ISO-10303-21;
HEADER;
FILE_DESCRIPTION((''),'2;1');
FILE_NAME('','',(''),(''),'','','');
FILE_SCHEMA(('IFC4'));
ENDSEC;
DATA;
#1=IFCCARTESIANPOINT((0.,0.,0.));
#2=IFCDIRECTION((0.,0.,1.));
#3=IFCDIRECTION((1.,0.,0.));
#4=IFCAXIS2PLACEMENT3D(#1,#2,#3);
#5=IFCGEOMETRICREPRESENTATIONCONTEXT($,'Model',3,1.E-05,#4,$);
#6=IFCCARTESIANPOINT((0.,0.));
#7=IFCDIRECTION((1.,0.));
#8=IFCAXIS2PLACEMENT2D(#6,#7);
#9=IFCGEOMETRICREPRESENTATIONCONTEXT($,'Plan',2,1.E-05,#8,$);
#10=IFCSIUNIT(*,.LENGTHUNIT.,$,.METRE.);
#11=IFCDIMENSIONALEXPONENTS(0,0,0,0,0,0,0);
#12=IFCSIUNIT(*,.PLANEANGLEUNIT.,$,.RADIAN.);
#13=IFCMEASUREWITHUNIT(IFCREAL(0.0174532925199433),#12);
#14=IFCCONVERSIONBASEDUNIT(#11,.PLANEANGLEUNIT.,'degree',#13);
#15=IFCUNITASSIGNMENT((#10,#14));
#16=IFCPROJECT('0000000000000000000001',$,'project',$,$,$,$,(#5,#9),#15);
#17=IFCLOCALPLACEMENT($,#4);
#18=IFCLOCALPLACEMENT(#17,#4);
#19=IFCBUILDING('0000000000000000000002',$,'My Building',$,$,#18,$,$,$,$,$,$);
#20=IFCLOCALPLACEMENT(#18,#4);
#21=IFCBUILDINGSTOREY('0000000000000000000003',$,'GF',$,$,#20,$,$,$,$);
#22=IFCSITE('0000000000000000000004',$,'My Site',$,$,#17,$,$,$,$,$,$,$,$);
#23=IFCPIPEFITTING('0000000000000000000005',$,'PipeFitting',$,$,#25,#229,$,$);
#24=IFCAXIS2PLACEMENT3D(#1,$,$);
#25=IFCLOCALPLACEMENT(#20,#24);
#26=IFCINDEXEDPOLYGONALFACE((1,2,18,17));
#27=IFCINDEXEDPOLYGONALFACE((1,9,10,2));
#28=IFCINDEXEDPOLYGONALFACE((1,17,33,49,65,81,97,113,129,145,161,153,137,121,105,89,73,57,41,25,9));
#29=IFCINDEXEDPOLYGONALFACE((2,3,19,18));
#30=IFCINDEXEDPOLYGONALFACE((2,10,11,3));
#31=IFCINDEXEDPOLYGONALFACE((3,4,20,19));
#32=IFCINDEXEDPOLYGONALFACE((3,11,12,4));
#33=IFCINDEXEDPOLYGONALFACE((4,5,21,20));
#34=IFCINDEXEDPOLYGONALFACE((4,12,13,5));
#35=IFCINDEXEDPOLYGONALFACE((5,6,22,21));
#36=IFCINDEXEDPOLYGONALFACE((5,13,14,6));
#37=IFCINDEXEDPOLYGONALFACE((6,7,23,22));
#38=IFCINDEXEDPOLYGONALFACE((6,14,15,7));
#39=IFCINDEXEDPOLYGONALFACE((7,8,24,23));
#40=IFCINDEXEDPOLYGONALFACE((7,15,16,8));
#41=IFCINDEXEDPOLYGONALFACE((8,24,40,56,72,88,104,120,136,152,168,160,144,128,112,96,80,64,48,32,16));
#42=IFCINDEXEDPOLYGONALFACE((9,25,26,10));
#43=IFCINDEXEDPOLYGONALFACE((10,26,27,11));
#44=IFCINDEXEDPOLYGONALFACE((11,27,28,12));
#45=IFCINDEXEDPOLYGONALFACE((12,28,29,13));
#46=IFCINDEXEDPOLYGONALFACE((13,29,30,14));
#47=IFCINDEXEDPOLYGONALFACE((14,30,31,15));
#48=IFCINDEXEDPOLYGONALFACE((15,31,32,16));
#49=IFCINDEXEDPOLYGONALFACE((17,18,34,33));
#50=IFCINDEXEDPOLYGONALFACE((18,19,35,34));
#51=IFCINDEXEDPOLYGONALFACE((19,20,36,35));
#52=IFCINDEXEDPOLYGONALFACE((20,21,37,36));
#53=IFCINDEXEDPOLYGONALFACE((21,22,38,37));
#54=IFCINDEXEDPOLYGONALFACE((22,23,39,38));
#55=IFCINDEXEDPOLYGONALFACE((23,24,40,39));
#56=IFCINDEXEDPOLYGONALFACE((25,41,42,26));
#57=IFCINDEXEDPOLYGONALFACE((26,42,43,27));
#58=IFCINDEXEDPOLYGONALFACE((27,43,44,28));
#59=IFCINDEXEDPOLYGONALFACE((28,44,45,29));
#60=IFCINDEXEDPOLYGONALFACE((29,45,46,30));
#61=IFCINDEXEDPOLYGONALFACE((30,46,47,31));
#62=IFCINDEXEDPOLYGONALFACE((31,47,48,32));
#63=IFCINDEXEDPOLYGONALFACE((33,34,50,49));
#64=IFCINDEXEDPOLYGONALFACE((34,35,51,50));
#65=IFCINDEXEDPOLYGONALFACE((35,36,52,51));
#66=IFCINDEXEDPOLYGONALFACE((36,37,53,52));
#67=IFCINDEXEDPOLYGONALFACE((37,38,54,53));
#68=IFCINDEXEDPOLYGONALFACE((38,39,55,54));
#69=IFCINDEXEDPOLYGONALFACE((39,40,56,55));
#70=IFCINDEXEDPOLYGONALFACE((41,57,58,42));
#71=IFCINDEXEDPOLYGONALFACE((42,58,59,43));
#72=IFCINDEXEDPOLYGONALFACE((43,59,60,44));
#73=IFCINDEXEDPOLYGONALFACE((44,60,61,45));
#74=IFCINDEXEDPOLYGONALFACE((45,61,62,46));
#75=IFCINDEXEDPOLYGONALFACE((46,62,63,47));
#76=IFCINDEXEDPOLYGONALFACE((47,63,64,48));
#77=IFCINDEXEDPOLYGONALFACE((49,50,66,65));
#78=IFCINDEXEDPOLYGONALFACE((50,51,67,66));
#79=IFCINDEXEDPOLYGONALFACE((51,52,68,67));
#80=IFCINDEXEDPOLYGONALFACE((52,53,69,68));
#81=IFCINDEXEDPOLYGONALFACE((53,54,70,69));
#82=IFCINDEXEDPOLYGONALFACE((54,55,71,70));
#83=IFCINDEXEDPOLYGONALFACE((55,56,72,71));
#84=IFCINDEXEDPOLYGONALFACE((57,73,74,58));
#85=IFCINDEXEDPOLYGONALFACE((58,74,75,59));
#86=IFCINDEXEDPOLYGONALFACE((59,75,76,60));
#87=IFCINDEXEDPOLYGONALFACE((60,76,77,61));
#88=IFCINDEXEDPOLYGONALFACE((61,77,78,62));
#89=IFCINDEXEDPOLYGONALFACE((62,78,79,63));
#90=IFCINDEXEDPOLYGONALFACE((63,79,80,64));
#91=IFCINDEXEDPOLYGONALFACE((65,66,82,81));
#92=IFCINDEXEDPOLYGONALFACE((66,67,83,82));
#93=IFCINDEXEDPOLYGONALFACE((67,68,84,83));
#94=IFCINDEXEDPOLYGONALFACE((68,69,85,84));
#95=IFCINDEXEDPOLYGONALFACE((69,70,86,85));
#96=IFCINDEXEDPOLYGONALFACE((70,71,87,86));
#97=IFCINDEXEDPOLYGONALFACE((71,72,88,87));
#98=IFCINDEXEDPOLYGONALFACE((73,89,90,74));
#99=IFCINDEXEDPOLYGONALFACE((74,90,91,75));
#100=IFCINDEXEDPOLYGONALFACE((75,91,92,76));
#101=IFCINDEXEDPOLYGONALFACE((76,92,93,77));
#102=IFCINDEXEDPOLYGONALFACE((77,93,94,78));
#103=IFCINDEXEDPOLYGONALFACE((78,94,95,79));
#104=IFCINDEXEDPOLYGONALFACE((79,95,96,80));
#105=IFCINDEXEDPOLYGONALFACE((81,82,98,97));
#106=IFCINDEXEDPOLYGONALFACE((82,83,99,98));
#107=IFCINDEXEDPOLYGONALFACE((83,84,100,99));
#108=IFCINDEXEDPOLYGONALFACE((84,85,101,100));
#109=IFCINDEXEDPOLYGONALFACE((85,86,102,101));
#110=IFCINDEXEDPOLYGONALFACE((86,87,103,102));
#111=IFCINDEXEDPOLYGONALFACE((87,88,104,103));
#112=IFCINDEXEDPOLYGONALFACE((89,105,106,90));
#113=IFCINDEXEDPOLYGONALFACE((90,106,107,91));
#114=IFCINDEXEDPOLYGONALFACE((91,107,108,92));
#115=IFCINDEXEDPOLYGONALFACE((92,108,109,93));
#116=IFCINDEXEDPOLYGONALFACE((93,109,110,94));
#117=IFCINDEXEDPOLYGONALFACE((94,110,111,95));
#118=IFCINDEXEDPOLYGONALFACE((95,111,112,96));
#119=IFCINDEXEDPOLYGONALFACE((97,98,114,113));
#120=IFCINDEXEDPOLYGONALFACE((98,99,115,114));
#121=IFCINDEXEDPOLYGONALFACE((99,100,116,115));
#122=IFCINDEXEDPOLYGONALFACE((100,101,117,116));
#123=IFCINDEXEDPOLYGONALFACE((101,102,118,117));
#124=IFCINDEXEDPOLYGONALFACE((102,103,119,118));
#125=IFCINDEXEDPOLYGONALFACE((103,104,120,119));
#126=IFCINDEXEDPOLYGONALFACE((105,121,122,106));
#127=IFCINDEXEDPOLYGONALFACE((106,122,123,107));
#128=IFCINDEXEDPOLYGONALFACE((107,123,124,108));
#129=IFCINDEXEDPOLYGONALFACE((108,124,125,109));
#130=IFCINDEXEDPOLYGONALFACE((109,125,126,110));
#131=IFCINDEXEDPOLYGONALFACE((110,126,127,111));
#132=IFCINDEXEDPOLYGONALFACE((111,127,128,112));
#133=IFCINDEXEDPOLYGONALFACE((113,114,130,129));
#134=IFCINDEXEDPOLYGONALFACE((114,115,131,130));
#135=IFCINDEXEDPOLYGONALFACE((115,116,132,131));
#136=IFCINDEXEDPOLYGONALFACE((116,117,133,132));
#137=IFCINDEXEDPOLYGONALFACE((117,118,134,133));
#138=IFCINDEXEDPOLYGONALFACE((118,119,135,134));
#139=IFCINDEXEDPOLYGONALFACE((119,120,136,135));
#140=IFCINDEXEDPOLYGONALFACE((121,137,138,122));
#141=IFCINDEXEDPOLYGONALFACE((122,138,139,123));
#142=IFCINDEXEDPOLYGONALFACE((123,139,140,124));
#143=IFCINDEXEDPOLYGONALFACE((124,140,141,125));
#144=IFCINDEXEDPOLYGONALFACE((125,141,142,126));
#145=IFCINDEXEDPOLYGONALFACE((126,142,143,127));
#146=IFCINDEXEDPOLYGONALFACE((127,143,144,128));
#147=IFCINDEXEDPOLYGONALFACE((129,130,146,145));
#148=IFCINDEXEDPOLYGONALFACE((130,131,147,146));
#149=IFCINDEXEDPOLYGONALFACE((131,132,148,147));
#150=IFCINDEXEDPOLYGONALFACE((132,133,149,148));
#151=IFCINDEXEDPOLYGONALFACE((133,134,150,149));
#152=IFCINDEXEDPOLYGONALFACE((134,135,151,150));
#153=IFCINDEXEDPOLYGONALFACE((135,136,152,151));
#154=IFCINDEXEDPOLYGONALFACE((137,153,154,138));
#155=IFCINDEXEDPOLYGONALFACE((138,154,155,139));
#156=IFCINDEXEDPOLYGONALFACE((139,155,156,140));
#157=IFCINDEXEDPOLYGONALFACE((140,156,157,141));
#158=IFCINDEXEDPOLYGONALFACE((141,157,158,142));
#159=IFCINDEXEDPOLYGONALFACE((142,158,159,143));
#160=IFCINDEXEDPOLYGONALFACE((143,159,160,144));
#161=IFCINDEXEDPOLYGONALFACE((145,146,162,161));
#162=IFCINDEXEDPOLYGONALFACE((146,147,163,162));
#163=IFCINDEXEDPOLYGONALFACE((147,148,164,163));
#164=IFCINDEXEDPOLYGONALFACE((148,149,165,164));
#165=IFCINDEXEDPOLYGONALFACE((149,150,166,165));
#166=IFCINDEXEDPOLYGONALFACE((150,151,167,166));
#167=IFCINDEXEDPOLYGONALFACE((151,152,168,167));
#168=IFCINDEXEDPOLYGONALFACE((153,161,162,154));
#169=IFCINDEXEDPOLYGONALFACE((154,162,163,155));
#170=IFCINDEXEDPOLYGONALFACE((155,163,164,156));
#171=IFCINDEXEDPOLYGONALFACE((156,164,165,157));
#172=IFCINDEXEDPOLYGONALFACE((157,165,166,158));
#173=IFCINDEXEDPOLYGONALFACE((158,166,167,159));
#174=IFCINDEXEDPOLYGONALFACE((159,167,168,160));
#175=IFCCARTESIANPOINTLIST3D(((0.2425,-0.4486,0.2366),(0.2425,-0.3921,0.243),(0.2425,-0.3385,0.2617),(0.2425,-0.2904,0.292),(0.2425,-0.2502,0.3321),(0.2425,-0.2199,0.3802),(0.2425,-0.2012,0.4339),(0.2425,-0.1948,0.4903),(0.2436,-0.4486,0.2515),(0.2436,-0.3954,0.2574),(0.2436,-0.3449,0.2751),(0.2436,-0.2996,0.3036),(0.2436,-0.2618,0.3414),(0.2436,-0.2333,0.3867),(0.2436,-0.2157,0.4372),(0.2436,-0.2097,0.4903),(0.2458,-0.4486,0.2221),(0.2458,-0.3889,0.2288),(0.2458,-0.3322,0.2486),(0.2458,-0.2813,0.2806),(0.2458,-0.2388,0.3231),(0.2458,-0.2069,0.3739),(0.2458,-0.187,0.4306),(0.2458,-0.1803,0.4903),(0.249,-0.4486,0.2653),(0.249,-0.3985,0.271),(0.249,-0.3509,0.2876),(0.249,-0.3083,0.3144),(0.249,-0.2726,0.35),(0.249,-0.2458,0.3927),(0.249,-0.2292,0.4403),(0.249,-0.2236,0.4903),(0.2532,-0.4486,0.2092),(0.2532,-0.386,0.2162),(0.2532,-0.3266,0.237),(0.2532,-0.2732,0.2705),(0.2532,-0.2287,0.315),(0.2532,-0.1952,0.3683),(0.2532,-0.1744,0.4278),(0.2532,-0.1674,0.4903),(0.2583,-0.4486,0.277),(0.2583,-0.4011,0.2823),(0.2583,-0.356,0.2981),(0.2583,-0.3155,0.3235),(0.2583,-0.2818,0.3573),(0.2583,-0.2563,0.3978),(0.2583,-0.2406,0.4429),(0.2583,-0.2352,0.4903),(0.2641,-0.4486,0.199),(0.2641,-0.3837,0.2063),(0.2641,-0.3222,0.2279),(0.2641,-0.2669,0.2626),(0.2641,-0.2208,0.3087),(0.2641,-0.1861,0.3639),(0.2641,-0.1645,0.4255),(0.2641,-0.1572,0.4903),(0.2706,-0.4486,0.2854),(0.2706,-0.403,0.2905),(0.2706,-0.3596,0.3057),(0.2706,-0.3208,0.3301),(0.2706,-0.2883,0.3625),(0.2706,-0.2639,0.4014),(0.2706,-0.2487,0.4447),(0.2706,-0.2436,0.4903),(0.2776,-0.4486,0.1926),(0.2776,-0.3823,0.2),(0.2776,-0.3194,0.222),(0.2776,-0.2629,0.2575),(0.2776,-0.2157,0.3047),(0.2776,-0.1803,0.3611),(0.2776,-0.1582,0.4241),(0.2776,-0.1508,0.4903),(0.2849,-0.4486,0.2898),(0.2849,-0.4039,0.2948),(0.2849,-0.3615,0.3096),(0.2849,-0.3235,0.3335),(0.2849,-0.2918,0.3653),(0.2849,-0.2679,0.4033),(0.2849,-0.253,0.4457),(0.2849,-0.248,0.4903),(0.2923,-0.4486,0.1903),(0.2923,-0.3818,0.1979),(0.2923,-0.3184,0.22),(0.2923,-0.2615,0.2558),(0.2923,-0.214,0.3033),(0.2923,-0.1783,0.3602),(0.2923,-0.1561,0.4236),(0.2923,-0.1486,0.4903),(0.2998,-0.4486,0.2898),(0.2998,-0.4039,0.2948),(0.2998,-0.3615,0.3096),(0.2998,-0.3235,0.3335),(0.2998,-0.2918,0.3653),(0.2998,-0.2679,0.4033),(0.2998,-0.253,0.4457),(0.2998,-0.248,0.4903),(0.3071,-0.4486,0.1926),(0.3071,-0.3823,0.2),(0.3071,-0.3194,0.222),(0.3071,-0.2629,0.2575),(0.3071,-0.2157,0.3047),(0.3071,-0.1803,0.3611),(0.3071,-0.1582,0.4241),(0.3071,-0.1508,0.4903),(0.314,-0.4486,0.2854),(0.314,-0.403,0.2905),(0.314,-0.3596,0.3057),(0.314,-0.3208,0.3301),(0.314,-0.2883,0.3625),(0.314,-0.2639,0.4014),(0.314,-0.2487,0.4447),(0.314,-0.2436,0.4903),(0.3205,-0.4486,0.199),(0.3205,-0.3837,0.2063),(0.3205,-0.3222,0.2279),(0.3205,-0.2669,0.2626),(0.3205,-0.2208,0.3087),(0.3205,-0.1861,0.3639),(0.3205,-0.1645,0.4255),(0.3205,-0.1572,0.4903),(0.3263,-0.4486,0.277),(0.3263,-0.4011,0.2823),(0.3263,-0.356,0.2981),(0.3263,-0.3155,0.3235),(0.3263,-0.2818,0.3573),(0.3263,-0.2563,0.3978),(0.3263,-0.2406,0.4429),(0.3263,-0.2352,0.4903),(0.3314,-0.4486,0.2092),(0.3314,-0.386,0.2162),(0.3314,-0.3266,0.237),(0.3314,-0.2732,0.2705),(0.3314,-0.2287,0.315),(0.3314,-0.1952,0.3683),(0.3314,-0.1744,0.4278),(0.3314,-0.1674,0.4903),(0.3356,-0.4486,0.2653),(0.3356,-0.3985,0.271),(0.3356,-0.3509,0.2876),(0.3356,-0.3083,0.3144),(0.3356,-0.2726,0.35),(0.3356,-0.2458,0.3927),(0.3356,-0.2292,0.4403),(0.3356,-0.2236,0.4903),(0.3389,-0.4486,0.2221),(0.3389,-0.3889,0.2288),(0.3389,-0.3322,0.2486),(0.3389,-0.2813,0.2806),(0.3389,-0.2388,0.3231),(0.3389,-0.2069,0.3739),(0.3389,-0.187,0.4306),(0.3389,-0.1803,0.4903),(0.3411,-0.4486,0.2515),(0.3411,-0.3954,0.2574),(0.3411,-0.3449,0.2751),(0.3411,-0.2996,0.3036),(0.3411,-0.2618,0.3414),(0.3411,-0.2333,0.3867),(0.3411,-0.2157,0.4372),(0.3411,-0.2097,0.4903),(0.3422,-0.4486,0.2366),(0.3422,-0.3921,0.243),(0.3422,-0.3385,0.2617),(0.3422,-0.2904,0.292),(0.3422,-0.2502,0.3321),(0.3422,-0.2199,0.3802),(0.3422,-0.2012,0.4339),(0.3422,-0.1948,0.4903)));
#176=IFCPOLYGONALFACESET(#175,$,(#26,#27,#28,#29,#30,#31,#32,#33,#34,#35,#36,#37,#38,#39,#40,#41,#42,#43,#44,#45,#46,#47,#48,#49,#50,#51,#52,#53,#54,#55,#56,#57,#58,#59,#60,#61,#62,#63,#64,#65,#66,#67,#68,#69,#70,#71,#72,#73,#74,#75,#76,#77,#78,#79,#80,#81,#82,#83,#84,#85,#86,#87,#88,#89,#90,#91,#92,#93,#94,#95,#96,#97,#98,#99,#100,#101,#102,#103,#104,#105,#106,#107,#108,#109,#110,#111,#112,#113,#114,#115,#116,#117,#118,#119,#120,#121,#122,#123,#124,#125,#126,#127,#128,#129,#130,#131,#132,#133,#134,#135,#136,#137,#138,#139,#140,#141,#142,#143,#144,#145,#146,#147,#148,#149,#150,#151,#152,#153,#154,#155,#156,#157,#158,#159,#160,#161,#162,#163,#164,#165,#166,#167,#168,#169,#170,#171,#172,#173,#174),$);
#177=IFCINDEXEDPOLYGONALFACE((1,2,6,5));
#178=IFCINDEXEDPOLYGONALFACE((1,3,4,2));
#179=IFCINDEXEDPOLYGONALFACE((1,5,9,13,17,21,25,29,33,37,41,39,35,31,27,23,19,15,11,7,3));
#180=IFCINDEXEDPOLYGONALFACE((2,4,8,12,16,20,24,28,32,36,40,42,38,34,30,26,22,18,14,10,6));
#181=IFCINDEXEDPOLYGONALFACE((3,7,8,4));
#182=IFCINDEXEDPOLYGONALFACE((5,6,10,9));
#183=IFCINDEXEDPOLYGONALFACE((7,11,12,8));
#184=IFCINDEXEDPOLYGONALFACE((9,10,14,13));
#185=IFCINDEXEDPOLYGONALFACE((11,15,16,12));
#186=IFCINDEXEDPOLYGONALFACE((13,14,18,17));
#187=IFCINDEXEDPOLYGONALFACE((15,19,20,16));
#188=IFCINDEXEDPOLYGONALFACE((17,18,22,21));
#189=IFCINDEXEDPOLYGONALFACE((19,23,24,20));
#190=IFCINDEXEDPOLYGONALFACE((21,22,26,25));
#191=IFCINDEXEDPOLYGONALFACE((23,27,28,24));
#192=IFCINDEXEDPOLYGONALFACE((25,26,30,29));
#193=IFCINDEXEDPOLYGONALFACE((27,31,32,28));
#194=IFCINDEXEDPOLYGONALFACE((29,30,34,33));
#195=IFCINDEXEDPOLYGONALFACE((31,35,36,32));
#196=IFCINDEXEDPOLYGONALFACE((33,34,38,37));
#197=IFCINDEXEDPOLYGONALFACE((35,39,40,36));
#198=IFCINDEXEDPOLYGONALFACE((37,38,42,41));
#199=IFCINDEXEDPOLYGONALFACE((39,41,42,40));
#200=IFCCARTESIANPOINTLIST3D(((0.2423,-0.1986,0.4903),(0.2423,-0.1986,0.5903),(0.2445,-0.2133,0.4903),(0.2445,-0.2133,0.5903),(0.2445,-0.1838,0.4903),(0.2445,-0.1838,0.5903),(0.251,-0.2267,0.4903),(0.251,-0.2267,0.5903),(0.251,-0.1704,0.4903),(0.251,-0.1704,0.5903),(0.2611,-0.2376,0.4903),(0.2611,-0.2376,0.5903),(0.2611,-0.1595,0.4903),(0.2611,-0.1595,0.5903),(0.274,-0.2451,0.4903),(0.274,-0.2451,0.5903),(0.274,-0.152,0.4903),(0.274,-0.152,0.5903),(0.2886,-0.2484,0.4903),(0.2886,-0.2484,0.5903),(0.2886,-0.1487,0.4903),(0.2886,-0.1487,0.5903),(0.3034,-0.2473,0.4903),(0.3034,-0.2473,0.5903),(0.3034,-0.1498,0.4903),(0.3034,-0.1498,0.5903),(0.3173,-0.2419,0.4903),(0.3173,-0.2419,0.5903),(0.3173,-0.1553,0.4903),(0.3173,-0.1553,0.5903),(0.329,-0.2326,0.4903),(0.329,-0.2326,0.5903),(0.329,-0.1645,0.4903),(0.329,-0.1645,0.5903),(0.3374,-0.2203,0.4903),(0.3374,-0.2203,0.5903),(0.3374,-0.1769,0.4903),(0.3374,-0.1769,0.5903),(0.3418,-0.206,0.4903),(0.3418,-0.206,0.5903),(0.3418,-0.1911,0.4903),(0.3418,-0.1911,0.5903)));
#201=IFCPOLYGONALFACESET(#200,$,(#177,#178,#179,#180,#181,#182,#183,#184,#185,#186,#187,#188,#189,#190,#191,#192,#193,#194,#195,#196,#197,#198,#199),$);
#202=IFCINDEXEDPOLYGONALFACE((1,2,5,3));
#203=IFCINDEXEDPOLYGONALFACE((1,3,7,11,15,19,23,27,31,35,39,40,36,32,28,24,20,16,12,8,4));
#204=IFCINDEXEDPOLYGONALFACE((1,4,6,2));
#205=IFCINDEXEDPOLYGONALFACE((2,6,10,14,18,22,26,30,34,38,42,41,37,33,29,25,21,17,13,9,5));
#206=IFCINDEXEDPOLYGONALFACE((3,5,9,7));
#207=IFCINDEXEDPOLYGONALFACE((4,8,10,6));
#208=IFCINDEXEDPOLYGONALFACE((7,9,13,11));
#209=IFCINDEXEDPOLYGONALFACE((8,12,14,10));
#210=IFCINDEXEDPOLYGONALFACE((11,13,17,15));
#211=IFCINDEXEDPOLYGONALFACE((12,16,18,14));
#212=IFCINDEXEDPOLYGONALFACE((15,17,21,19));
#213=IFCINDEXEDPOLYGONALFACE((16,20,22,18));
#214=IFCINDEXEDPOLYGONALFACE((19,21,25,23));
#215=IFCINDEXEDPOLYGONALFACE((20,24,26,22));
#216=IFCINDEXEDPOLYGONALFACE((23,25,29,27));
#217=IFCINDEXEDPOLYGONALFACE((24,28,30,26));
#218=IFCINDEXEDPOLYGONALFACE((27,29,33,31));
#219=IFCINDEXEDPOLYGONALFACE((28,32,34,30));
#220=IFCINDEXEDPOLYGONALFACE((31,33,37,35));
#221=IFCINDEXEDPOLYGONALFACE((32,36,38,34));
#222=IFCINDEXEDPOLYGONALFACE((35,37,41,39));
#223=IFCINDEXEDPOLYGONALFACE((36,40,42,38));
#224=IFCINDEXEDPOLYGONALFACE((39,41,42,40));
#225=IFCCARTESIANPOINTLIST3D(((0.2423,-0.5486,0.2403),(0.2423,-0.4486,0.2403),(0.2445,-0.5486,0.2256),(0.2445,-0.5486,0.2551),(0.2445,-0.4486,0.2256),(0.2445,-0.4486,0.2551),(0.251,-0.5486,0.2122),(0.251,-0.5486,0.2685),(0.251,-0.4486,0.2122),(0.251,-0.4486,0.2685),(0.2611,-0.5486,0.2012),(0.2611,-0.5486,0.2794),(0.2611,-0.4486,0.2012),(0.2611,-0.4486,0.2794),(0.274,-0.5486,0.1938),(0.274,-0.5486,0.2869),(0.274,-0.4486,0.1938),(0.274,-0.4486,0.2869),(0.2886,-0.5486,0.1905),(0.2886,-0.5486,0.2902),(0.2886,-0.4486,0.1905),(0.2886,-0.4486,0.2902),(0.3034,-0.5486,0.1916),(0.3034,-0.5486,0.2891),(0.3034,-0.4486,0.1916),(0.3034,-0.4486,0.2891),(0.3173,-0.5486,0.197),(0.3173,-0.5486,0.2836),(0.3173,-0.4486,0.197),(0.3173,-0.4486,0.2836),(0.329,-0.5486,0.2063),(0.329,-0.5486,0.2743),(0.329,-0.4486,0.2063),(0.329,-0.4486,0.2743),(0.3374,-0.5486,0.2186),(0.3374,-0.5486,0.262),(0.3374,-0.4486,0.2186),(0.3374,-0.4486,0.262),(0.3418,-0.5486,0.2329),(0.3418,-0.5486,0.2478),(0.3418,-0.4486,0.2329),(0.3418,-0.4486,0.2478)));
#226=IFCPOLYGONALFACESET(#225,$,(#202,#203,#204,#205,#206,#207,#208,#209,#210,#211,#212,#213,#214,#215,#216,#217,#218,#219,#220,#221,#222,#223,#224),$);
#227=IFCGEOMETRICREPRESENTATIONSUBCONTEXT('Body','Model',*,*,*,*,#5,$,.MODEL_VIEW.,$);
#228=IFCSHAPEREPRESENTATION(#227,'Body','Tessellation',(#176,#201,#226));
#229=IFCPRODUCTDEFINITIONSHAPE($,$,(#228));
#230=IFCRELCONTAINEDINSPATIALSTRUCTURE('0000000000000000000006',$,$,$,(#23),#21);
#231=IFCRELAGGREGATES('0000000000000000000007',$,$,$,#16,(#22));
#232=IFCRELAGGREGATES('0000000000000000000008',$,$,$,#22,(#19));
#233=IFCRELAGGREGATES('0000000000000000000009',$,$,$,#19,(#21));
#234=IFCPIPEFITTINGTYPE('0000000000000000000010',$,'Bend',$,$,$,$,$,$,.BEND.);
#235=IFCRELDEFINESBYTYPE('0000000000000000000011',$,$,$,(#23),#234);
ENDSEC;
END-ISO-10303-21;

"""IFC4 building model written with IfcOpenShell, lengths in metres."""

from ifc_helpers import new_model, entity, si_unit, converted_unit, frame, origin_with_axes, origin_2d_with_axis, place, context, subcontext, project, spatial, circle, extrude, source, transform, mapped, type_object, type_shapes, element, save


model = new_model("IFC4")

# Units and contexts
model_context = context("Model", 3, precision=1e-05, world=origin_with_axes())
plan_context = context("Plan", 2, precision=1e-05, world=origin_2d_with_axis())
body_context_1 = subcontext(model_context, "Body", "Model", "MODEL_VIEW")
ifc_project = project(units=[si_unit("LENGTHUNIT", "METRE"), converted_unit("PLANEANGLEUNIT", "degree", entity("IfcReal", 0.0174532925199433), si_unit("PLANEANGLEUNIT", "RADIAN"), dimensions=[0, 0, 0, 0, 0, 0, 0])], contexts=[model_context, plan_context])

# Site, building, storey
site_placement = place(None, origin_with_axes())
site = spatial("IfcSite", under=ifc_project, at=site_placement, Name="My Site")
building_placement = place(site_placement, origin_with_axes())
building = spatial("IfcBuilding", under=site, at=building_placement, Name="My Building")
storey_placement = place(building_placement, origin_with_axes())
storey = spatial("IfcBuildingStorey", under=building, at=storey_placement, Name="GF")

# Pipe fitting
pipe_fitting_type = type_object("IfcPipeFittingType", Name="Bend", PredefinedType="BEND")
shared_shape_1 = source(origin_with_axes(), body_context_1, "Body", "SolidModel", [
    entity("IfcSweptDiskSolid", entity("IfcIndexedPolyCurve", entity("IfcCartesianPointList3D", [[0.0, 0.0, -0.1], [0.0, 0.0732, -0.2768], [0.0, 0.25, -0.35]]), [entity("IfcArcIndex", [1, 2, 3])]), 0.05),
    extrude(circle(Radius=0.05), origin_with_axes(), (0.0, 0.0, -1.0), 0.1),
    extrude(circle(Radius=0.05), frame((0.0, 0.25, -0.35), z_axis=(0.0, 1.0, 0.000007), x_axis=(1.0, 0.0, 0.0)), (0.0, 0.0, 1.0), 0.1),
])
type_shapes(pipe_fitting_type, [shared_shape_1])
pipe_fitting_placement = place(storey_placement, frame((0.2923, -0.1986, 0.5903), z_axis=(0.0, 0.0, 1.0), x_axis=(-1.0, 0.0, 0.0)))
element("IfcPipeFitting", 1, at=pipe_fitting_placement, inside=storey, type_object=pipe_fitting_type, Name="PipeFitting", context=body_context_1, shape_type="MappedRepresentation", body=[
    mapped(shared_shape_1, transform((0.0, 0.0, 0.0), x_axis=(1.0, 0.0, 0.0), y_axis=(0.0, 1.0, 0.0), z_axis=(0.0, 0.0, 1.0), scale=1.0)),
])

save(model, "model.ifc")
